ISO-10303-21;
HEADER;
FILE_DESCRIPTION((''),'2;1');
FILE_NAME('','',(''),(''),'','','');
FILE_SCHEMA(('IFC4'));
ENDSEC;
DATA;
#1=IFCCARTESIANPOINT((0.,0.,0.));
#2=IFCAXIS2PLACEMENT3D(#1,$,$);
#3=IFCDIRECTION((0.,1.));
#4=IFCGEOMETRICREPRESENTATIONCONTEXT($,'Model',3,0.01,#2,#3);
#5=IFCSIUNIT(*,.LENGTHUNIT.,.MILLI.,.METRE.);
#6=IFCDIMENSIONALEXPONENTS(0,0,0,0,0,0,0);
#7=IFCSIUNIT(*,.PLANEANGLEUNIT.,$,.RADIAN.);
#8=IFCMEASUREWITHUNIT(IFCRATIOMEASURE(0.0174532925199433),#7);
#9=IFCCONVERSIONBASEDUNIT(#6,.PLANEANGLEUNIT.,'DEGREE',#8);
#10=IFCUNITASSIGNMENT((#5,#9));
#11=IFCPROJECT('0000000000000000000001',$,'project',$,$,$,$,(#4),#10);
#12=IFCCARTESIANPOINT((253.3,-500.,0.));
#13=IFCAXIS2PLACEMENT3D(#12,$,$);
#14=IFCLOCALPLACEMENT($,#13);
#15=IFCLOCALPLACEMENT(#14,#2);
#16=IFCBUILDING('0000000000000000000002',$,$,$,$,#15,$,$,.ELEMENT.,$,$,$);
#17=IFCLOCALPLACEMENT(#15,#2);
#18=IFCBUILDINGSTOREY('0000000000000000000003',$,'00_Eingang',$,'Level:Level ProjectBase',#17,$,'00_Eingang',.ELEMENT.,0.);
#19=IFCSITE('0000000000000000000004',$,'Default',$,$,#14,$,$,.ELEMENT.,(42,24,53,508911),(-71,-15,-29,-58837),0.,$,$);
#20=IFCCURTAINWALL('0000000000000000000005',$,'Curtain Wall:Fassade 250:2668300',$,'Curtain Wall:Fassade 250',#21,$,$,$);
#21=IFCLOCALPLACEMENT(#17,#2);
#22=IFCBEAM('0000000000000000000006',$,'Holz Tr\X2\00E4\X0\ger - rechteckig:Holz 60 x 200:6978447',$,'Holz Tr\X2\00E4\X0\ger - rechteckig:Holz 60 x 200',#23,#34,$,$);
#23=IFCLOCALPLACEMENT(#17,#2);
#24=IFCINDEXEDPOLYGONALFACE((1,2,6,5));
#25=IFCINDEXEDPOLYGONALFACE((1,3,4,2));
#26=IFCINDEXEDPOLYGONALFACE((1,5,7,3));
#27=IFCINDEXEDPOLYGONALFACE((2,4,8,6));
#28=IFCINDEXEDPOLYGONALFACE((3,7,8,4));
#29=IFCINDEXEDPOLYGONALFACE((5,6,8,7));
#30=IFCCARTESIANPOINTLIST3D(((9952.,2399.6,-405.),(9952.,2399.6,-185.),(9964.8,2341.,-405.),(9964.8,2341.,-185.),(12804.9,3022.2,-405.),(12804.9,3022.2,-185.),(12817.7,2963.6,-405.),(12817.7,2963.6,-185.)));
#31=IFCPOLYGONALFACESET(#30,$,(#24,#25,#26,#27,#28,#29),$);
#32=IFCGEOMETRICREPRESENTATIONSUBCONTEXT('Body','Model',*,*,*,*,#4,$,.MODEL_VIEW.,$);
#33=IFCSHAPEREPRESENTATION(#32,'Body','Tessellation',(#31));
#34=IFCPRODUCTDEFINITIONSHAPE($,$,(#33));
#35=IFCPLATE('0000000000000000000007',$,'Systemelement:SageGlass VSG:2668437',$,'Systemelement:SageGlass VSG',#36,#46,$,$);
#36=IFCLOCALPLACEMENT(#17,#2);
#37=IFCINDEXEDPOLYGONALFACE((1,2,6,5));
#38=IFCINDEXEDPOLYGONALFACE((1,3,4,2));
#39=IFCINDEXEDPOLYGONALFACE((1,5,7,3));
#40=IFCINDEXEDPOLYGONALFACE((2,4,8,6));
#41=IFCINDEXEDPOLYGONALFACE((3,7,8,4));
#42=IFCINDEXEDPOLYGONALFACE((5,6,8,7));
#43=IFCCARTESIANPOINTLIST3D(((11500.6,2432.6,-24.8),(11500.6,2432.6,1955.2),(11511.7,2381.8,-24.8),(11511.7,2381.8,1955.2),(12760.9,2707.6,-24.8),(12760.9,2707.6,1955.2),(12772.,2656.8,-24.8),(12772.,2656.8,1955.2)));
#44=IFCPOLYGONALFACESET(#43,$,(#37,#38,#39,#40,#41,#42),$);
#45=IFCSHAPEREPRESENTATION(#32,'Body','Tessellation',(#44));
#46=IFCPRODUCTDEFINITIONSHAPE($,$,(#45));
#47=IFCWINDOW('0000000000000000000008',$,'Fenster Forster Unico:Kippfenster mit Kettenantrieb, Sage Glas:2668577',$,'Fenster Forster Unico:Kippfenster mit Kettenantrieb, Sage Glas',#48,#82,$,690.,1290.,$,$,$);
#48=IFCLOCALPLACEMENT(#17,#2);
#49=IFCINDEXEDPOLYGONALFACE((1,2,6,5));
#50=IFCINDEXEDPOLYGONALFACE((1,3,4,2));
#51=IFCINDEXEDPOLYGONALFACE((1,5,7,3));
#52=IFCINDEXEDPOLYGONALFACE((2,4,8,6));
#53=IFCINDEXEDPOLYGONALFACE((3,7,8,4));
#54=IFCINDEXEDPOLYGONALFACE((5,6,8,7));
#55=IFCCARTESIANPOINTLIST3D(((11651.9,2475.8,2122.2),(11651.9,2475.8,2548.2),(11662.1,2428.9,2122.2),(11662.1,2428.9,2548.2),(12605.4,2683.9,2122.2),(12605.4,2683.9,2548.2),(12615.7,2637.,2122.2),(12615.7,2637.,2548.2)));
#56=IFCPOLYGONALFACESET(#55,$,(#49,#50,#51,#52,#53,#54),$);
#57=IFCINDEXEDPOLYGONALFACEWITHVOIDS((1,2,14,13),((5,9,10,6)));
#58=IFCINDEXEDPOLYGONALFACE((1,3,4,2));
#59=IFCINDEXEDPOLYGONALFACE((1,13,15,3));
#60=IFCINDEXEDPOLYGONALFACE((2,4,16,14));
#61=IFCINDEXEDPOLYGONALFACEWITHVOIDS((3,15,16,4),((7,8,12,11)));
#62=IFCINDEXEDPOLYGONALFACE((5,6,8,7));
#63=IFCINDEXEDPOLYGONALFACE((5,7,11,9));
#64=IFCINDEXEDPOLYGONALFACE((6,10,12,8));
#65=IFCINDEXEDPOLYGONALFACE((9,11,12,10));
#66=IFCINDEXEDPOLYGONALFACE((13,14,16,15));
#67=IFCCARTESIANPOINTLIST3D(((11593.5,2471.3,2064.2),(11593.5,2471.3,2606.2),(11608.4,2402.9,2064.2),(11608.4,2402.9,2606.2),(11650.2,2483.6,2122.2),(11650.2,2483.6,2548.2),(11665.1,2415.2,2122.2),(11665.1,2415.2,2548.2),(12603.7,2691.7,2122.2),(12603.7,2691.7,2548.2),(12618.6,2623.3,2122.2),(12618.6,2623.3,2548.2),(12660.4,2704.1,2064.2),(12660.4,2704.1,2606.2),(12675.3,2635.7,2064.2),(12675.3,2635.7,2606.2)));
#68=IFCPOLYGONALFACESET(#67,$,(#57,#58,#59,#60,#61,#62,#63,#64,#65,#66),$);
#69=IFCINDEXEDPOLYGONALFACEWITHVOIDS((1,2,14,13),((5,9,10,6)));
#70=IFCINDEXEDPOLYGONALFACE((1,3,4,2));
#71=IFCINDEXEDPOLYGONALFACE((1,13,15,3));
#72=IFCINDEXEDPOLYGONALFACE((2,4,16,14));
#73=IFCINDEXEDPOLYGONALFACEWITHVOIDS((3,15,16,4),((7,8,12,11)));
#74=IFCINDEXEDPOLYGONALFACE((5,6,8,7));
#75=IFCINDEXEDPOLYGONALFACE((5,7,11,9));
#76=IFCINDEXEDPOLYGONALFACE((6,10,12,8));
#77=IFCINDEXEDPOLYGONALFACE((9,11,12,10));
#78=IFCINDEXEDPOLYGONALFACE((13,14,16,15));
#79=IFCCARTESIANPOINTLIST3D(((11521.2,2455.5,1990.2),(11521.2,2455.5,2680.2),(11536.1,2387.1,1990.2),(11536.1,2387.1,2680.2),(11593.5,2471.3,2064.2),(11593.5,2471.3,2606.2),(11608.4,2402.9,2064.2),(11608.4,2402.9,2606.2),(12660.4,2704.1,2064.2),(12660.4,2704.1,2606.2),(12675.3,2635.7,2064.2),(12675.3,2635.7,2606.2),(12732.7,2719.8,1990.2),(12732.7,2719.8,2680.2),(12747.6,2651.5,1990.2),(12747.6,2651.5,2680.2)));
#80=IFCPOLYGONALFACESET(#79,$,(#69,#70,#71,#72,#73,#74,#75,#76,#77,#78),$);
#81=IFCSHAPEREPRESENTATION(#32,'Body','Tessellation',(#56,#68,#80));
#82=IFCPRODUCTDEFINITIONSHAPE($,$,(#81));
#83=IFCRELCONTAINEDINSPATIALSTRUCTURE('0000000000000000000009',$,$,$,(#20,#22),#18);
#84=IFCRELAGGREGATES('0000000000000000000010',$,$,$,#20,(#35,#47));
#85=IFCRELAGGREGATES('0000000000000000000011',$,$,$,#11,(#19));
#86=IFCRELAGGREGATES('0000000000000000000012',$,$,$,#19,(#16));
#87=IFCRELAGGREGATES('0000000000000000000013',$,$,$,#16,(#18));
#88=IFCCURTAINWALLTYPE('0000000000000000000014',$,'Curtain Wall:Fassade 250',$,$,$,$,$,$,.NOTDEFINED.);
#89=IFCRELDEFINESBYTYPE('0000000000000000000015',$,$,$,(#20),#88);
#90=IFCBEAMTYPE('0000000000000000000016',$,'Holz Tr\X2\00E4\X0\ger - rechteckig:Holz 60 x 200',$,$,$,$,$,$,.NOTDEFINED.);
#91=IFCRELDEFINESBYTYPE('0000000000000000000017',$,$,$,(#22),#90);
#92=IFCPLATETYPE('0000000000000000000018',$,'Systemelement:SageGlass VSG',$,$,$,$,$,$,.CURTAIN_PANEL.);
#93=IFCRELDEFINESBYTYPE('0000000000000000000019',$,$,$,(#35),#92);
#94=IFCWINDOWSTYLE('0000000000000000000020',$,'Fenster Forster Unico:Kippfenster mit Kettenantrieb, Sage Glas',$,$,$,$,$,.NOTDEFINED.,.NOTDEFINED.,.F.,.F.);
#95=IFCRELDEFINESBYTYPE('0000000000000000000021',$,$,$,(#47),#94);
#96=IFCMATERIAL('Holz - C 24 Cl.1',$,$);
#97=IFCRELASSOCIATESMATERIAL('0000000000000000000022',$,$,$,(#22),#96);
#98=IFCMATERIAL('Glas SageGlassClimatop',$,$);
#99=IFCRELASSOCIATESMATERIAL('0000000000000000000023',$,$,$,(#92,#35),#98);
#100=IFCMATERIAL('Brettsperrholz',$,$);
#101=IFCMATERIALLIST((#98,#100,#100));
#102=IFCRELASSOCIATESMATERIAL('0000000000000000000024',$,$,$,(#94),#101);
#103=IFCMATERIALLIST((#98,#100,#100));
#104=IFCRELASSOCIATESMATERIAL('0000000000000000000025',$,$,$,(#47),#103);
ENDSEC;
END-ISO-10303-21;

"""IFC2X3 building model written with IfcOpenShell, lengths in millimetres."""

from ifc_helpers import new_model, entity, si_unit, converted_unit, direction, frame, frame_2d, origin, origin_2d_with_axis, place, context, subcontext, project, spatial, polyline, rectangle, outline, extrude, source, transform, mapped, material, material_list, type_object, type_shapes, element, aggregate, save


model = new_model("IFC2X3")

# Units and contexts
model_context = context("Model", 3, precision=0.01, world=origin(), true_north=direction((0.0, 1.0)))
body_context = subcontext(model_context, "Body", "Model", "MODEL_VIEW")
ifc_project = project(units=[si_unit("LENGTHUNIT", "METRE", prefix="MILLI"), converted_unit("PLANEANGLEUNIT", "DEGREE", entity("IfcRatioMeasure", 0.0174532925199433), si_unit("PLANEANGLEUNIT", "RADIAN"), dimensions=[0, 0, 0, 0, 0, 0, 0])], contexts=[model_context])

# Site, building, storey
site_placement = place(None, frame((253.3, -500.0, 0.0)))
site = spatial("IfcSite", under=ifc_project, at=site_placement, Name="Default", CompositionType="ELEMENT", RefLatitude=(42, 24, 53, 508911), RefLongitude=(-71, -15, -29, -58837), RefElevation=0.0)
building_placement = place(site_placement, origin())
building = spatial("IfcBuilding", under=site, at=building_placement, CompositionType="ELEMENT")
storey_placement = place(building_placement, origin())
storey = spatial("IfcBuildingStorey", under=building, at=storey_placement, Name="00_Eingang", ObjectType="Level:Level ProjectBase", LongName="00_Eingang", CompositionType="ELEMENT", Elevation=0.0)

# Curtain wall
curtain_wall_type = type_object("IfcCurtainWallType", Name="Curtain Wall:Fassade 250", PredefinedType="NOTDEFINED")
curtain_wall_1_placement = place(storey_placement, origin())
curtain_wall_1 = element("IfcCurtainWall", 1, at=curtain_wall_1_placement, inside=storey, type_object=curtain_wall_type, Name="Curtain Wall:Fassade 250:2668300", ObjectType="Curtain Wall:Fassade 250")

# Beam
ifc_material_1 = material(Name="Holz - C 24 Cl.1")
beam_type = type_object("IfcBeamType", Name="Holz Träger - rechteckig:Holz 60 x 200", PredefinedType="NOTDEFINED")
beam_placement = place(storey_placement, frame((9958.4, 2370.3, 0.0), z_axis=(0.0, 0.0, 1.0), x_axis=(0.977008, 0.213201, 0.0)))
element("IfcBeam", 2, at=beam_placement, inside=storey, type_object=beam_type, material=ifc_material_1, Name="Holz Träger - rechteckig:Holz 60 x 200:6978447", ObjectType="Holz Träger - rechteckig:Holz 60 x 200", context=body_context, shape_type="SweptSolid", body=[
    extrude(rectangle(XDim=220.0, YDim=60.0, at=frame_2d((0.0, 0.0), x_axis=(1.0, 0.0))), frame((0.0, 0.0, -295.0), z_axis=(1.0, 0.0, 0.0), x_axis=(0.0, 0.0, -1.0)), (0.0, 0.0, 1.0), 2920.0),
])

# Plate
ifc_material_2 = material(Name="Glas SageGlassClimatop")
plate_type_1 = type_object("IfcPlateType", Name="Systemelement:SageGlass VSG", PredefinedType="CURTAIN_PANEL", material=ifc_material_2)
shared_shape_1 = source(origin(), body_context, "Body", "SweptSolid", [
    extrude(rectangle(XDim=1980.0, YDim=1290.0, at=frame_2d((-268.3, 0.0), x_axis=(1.0, 0.0))), frame((0.0, -26.0, 1258.3), z_axis=(0.0, 1.0, 0.0), x_axis=(0.0, 0.0, 1.0)), (0.0, 0.0, 1.0), 52.0),
])
type_shapes(plate_type_1, [shared_shape_1])
plate_1_placement = place(curtain_wall_1_placement, frame((12136.3, 2544.7, -24.8), z_axis=(0.0, 0.0, 1.0), x_axis=(0.977008, 0.213201, 0.0)))
plate_1 = element("IfcPlate", 3, at=plate_1_placement, type_object=plate_type_1, material=ifc_material_2, Name="Systemelement:SageGlass VSG:2668437", ObjectType="Systemelement:SageGlass VSG", context=body_context, shape_type="MappedRepresentation", body=[
    mapped(shared_shape_1, transform((0.0, 0.0, 0.0), scale=1.0)),
])

# Window
ifc_material_3 = material(Name="Brettsperrholz")
ifc_material_list_1 = material_list([ifc_material_2, ifc_material_3, ifc_material_3])
ifc_material_list_2 = material_list([ifc_material_2, ifc_material_3, ifc_material_3])
window_style = type_object("IfcWindowStyle", Name="Fenster Forster Unico:Kippfenster mit Kettenantrieb, Sage Glas", ConstructionType="NOTDEFINED", OperationType="NOTDEFINED", ParameterTakesPrecedence=False, Sizeable=False, material=ifc_material_list_2)
shared_shape_2 = source(origin(), body_context, "Body", "SweptSolid", [
    extrude(rectangle(XDim=48.0, YDim=976.0, at=origin_2d_with_axis()), frame((0.0, 12.0, 157.0), z_axis=(0.0, 0.0, 1.0), x_axis=(0.0, 1.0, 0.0)), (0.0, 0.0, 1.0), 426.0),
    extrude(outline(polyline([(-546.0, -271.0), (546.0, -271.0), (546.0, 271.0), (-546.0, 271.0), (-546.0, -271.0)]), holes=[polyline([(-488.0, 213.0), (488.0, 213.0), (488.0, -213.0), (-488.0, -213.0), (-488.0, 213.0)])]), frame((0.0, -26.0, 370.0), z_axis=(0.0, 1.0, 0.0), x_axis=(1.0, 0.0, 0.0)), (0.0, 0.0, 1.0), 70.0),
    extrude(outline(polyline([(-620.0, -345.0), (620.0, -345.0), (620.0, 345.0), (-620.0, 345.0), (-620.0, -345.0)]), holes=[polyline([(-546.0, 271.0), (546.0, 271.0), (546.0, -271.0), (-546.0, -271.0), (-546.0, 271.0)])]), frame((0.0, -26.0, 370.0), z_axis=(0.0, 1.0, 0.0), x_axis=(1.0, 0.0, 0.0)), (0.0, 0.0, 1.0), 70.0),
])
type_shapes(window_style, [shared_shape_2])
window_placement = place(curtain_wall_1_placement, frame((12136.3, 2544.7, 1965.2), z_axis=(0.0, 0.0, 1.0), x_axis=(0.977008, 0.213201, 0.0)))
window = element("IfcWindow", 4, at=window_placement, type_object=window_style, material=ifc_material_list_1, Name="Fenster Forster Unico:Kippfenster mit Kettenantrieb, Sage Glas:2668577", ObjectType="Fenster Forster Unico:Kippfenster mit Kettenantrieb, Sage Glas", OverallHeight=690.0, OverallWidth=1290.0, context=body_context, shape_type="MappedRepresentation", body=[
    mapped(shared_shape_2, transform((0.0, 0.0, 0.0), scale=1.0)),
])
aggregate(curtain_wall_1, [plate_1, window])

save(model, "model.ifc")
